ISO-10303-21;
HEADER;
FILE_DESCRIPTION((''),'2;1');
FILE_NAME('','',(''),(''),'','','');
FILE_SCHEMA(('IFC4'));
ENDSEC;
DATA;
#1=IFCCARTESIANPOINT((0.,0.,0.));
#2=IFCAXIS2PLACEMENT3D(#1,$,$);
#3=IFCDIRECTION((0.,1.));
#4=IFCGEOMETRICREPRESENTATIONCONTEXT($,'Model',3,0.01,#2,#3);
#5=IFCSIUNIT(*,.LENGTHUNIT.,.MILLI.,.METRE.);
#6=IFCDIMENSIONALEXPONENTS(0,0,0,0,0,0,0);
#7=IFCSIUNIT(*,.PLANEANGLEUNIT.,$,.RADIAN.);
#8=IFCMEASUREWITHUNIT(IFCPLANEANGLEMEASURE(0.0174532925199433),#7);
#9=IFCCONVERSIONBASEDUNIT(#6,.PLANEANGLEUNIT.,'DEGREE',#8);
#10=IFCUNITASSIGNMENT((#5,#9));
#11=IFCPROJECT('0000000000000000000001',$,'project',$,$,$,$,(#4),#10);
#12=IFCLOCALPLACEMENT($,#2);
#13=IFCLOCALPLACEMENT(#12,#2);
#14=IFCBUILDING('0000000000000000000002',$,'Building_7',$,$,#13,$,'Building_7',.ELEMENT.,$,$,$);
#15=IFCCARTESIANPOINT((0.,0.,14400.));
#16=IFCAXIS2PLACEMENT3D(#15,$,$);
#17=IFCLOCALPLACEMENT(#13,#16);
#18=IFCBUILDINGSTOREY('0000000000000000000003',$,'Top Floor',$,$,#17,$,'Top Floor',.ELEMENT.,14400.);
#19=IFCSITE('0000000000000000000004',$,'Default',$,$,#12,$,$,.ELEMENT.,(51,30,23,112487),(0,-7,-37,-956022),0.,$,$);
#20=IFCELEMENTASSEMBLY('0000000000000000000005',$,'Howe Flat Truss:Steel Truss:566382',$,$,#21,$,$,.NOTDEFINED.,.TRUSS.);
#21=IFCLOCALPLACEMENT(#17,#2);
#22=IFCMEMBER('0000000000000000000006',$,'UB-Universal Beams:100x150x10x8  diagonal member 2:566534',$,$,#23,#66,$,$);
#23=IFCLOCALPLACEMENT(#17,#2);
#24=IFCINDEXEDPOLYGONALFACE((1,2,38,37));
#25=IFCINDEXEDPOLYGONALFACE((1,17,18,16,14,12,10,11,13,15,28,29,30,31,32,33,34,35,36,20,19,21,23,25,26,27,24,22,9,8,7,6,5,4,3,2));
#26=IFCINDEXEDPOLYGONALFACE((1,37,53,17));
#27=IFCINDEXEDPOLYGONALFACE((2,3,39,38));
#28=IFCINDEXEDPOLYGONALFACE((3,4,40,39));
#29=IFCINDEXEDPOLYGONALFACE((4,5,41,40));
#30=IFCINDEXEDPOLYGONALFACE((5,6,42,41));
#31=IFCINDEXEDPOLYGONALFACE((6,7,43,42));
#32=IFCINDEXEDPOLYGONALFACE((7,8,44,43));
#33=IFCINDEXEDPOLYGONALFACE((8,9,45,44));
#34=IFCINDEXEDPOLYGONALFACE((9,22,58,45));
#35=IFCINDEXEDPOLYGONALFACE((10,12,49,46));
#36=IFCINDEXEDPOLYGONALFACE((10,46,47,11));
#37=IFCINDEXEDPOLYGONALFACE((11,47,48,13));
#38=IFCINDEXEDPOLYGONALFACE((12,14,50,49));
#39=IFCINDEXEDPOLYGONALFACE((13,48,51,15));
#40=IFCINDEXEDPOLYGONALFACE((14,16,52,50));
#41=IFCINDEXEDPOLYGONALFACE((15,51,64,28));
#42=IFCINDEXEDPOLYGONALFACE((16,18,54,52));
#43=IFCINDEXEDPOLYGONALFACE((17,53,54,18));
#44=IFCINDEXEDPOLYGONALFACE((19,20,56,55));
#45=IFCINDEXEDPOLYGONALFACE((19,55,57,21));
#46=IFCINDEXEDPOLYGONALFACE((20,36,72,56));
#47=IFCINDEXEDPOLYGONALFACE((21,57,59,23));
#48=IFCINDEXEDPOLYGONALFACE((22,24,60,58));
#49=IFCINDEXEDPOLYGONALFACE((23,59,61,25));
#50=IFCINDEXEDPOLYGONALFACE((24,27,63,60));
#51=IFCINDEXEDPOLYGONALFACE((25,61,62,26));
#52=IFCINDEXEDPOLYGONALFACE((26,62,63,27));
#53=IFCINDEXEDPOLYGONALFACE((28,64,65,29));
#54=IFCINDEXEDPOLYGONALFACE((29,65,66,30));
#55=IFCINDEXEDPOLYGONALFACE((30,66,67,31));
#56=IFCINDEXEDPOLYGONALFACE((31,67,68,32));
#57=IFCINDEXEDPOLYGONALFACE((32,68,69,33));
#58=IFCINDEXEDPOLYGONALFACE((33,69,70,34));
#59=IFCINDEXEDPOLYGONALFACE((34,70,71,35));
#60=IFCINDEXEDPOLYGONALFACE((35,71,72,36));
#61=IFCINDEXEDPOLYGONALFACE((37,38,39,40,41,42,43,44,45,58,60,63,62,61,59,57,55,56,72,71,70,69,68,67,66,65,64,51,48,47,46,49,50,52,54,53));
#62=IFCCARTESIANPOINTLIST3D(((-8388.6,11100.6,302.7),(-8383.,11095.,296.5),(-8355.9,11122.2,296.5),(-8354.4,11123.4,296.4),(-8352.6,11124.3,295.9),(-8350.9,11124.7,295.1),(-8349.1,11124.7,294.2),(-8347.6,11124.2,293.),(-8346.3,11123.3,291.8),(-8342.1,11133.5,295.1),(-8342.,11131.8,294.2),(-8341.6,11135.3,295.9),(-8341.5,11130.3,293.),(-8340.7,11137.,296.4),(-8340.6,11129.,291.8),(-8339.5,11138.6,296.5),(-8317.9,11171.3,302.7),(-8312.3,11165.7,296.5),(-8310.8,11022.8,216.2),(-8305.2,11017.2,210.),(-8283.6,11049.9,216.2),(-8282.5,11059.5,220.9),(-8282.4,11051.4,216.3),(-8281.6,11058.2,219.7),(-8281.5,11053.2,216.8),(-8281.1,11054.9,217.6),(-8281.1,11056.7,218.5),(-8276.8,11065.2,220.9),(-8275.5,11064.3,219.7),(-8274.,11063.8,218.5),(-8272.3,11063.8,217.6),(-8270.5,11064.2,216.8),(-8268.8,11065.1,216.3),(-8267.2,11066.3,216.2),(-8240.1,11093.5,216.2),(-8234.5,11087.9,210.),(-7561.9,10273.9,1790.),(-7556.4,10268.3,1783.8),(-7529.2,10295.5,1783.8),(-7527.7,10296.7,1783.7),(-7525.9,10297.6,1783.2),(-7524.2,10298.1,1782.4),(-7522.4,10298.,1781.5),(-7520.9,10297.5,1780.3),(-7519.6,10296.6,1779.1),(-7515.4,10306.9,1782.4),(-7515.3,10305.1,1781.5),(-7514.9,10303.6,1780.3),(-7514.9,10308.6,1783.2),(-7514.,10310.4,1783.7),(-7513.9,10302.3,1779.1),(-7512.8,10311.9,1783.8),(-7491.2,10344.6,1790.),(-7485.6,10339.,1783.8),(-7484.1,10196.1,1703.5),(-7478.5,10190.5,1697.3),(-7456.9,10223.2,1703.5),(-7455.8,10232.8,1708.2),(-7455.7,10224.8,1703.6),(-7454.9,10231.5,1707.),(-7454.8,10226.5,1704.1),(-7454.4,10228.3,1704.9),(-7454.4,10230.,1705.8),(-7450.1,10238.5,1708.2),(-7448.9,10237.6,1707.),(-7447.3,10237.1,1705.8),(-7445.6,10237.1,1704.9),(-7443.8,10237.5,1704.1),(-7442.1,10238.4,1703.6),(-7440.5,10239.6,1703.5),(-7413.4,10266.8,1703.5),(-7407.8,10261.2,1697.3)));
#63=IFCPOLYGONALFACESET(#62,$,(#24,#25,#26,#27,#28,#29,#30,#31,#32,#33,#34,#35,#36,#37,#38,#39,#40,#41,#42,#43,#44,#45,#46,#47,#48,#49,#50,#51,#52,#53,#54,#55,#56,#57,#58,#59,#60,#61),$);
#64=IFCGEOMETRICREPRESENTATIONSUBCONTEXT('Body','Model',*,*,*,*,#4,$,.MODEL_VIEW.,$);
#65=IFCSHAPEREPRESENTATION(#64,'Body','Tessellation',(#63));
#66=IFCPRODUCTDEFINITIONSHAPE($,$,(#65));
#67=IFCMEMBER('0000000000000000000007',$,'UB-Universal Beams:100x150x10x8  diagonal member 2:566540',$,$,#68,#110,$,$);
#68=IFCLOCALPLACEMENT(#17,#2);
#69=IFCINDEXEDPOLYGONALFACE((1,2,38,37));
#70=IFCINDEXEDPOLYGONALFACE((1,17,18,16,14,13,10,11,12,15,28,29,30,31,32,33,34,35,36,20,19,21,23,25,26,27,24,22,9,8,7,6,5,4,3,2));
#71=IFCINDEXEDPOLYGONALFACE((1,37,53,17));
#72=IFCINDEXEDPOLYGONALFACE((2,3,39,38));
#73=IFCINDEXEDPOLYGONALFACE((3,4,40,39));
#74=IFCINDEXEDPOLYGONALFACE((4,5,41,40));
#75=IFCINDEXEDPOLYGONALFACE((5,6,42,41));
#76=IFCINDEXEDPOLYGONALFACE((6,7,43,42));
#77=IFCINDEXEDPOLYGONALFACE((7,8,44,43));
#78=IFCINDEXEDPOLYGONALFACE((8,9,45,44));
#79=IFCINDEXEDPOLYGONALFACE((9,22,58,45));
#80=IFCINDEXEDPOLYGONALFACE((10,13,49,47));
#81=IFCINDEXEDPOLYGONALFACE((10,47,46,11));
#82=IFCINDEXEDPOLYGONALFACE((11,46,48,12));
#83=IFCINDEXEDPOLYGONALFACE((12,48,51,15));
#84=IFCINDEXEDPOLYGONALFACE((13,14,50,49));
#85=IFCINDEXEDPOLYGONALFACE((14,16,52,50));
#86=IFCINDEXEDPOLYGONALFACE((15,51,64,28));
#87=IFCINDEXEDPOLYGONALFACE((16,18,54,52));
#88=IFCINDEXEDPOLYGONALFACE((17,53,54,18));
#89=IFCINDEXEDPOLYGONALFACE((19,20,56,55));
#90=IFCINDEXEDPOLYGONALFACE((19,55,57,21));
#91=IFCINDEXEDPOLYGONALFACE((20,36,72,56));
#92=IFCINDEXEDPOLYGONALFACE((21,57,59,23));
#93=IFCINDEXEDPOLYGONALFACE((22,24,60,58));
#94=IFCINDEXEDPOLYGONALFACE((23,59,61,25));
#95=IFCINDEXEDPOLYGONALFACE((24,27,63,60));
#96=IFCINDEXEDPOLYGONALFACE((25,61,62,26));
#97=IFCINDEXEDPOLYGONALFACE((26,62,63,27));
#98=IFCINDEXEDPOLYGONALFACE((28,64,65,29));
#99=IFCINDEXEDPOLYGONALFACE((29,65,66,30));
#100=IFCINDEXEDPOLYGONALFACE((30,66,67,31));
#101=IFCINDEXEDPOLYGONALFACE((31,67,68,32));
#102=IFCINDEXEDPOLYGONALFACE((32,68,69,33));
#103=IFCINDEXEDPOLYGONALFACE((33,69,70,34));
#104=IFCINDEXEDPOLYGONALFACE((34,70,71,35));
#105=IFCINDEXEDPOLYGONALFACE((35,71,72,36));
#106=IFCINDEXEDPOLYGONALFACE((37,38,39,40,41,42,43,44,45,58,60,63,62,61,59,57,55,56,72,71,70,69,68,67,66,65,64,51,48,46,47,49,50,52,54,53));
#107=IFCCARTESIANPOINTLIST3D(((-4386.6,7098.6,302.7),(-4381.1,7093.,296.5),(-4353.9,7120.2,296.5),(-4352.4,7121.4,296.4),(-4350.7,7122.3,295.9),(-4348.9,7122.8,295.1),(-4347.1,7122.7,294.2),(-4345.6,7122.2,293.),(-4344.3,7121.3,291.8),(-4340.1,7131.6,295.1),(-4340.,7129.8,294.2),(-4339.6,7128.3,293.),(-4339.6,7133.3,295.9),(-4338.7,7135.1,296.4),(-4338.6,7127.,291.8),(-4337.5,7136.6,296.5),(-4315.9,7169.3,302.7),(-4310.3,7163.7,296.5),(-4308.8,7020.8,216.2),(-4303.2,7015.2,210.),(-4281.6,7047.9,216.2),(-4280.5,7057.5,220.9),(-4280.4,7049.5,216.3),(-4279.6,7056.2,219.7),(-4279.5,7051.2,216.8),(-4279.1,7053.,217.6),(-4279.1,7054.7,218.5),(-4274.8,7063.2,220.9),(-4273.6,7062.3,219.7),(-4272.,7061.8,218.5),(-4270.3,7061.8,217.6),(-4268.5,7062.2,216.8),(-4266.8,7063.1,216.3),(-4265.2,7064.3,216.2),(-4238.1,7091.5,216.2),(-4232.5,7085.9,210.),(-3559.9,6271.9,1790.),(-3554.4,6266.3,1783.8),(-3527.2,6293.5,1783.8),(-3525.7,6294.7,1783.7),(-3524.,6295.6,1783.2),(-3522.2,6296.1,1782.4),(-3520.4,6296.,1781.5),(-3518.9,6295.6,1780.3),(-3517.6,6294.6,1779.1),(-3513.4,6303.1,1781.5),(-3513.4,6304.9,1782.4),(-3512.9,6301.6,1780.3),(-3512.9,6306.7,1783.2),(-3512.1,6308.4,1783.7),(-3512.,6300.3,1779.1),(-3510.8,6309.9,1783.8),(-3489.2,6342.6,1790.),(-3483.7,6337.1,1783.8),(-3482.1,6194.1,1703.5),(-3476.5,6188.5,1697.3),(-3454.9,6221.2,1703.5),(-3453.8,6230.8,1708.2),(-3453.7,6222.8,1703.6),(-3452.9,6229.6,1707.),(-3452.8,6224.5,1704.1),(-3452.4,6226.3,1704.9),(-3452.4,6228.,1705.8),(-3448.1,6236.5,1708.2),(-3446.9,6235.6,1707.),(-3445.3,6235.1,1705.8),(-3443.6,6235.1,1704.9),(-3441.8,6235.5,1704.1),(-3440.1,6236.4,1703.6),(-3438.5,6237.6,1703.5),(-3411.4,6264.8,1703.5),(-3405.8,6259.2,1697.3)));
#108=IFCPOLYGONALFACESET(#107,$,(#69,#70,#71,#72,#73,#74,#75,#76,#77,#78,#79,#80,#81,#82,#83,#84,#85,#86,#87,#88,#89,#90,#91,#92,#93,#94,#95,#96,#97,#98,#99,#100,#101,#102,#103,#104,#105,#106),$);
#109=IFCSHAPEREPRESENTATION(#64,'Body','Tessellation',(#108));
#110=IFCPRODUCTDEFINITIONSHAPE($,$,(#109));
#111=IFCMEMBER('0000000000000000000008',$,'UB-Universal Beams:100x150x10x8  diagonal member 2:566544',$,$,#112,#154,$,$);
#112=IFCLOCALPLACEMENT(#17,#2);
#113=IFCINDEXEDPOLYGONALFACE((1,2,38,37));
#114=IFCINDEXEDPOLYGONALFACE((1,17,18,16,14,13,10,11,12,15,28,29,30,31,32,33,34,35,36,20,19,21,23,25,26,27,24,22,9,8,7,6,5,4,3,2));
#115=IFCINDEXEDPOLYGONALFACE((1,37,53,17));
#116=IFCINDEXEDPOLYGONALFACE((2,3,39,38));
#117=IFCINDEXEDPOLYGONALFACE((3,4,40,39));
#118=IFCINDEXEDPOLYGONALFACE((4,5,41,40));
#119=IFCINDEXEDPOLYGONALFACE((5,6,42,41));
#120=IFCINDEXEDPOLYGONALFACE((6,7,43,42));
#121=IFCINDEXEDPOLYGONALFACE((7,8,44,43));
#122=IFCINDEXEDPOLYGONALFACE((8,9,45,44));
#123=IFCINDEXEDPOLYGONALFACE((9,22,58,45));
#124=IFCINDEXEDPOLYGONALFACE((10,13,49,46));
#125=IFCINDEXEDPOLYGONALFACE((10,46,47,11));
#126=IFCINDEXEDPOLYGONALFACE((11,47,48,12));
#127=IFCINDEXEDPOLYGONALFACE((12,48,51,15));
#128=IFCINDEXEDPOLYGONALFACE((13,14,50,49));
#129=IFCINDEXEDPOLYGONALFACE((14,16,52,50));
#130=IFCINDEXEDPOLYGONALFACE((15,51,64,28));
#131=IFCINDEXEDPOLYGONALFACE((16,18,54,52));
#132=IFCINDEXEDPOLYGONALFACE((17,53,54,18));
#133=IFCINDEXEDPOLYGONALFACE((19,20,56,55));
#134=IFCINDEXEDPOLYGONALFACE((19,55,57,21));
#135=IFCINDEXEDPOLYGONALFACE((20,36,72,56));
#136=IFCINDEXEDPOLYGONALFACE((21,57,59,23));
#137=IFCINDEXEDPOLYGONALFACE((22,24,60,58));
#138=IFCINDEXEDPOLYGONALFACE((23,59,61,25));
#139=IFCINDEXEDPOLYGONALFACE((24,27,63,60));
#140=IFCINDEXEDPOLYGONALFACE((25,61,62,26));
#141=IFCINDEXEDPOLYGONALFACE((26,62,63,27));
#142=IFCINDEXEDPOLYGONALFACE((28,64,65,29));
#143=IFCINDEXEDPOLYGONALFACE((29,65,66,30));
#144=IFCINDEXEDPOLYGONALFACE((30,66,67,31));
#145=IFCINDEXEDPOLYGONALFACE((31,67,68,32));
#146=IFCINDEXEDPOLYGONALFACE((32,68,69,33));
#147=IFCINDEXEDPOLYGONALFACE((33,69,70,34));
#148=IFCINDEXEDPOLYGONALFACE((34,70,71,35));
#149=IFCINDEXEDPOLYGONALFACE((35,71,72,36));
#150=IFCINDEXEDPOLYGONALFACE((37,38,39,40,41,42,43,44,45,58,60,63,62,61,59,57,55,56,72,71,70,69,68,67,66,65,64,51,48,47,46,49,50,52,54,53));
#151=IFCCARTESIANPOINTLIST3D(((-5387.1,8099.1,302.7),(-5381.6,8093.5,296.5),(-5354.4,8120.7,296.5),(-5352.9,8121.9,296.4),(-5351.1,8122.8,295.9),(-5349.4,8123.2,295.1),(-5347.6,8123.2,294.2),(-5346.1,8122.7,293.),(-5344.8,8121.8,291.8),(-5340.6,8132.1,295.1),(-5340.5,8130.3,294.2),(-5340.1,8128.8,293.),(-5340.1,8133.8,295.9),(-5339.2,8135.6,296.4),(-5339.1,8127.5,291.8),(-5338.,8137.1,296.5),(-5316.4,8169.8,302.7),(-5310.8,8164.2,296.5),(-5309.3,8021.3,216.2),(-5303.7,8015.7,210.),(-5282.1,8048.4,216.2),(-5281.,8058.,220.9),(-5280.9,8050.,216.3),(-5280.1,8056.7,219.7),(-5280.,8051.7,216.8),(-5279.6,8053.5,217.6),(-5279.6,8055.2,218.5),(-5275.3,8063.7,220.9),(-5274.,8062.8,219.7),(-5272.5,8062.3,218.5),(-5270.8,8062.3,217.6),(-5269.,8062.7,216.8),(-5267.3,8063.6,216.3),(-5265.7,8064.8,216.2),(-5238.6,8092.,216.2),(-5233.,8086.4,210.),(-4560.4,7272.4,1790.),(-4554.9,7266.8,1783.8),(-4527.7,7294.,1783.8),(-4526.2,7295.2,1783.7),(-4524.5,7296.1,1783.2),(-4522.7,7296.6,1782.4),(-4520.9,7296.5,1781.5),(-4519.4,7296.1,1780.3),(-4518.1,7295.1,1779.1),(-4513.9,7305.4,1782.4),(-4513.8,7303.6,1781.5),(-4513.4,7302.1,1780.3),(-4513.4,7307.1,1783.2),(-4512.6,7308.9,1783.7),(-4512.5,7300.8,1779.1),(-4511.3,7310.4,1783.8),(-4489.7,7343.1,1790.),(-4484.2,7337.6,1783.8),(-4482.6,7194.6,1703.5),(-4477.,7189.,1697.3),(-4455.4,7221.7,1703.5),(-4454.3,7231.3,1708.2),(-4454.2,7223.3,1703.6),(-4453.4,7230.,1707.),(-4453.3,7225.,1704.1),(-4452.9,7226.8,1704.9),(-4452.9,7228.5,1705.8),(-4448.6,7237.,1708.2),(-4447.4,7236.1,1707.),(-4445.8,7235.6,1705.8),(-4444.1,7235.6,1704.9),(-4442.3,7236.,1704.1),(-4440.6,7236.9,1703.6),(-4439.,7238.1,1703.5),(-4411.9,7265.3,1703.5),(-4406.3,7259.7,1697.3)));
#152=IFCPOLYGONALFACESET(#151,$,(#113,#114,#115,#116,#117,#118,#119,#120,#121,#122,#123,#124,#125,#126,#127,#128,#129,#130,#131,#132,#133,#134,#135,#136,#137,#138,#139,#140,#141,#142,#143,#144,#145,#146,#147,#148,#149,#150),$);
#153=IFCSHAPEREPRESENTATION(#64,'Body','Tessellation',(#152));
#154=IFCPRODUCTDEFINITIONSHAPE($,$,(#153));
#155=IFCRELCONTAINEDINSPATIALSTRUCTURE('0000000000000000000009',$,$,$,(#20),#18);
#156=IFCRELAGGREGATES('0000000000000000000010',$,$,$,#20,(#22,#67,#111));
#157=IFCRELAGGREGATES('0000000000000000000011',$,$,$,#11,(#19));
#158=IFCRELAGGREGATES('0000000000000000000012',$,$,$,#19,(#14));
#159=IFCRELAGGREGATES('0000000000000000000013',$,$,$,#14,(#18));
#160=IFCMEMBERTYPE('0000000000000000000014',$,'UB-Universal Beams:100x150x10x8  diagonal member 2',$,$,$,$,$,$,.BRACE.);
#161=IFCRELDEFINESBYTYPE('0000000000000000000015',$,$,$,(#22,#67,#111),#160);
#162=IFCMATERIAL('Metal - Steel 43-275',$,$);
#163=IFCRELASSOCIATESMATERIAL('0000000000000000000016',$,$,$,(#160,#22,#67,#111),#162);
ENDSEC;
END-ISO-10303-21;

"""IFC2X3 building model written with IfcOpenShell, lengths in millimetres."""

from ifc_helpers import new_model, entity, si_unit, converted_unit, direction, frame, frame_2d, origin, place, context, subcontext, project, spatial, polyline, circle_curve, parameter, trimmed, segment, composite_curve, outline, extrude, source, transform, mapped, material, type_object, type_shapes, element, aggregate, save


model = new_model("IFC2X3")

# Units and contexts
model_context = context("Model", 3, precision=0.01, world=origin(), true_north=direction((0.0, 1.0)))
body_context = subcontext(model_context, "Body", "Model", "MODEL_VIEW")
ifc_project = project(units=[si_unit("LENGTHUNIT", "METRE", prefix="MILLI"), converted_unit("PLANEANGLEUNIT", "DEGREE", entity("IfcPlaneAngleMeasure", 0.0174532925199433), si_unit("PLANEANGLEUNIT", "RADIAN"), dimensions=[0, 0, 0, 0, 0, 0, 0])], contexts=[model_context])

# Site, building, storey
site_placement = place(None, origin())
site = spatial("IfcSite", under=ifc_project, at=site_placement, Name="Default", CompositionType="ELEMENT", RefLatitude=(51, 30, 23, 112487), RefLongitude=(0, -7, -37, -956022), RefElevation=0.0)
building_placement = place(site_placement, origin())
building = spatial("IfcBuilding", under=site, at=building_placement, Name="Building_7", LongName="Building_7", CompositionType="ELEMENT")
storey_placement = place(building_placement, frame((0.0, 0.0, 14400.0)))
storey = spatial("IfcBuildingStorey", under=building, at=storey_placement, Name="Top Floor", LongName="Top Floor", CompositionType="ELEMENT", Elevation=14400.0)

# Shared definitions
ifc_material = material(Name="Metal - Steel 43-275")

# Element assembly
assembly_1_placement = place(storey_placement, origin())
assembly_1 = element("IfcElementAssembly", 1, at=assembly_1_placement, inside=storey, Name="Howe Flat Truss:Steel Truss:566382", AssemblyPlace="NOTDEFINED", PredefinedType="TRUSS")

# Members
member_type_1 = type_object("IfcMemberType", Name="UB-Universal Beams:100x150x10x8  diagonal member 2", PredefinedType="BRACE", material=ifc_material)
shared_shape_1 = source(origin(), body_context, "Body", "SweptSolid", [
    extrude(outline(composite_curve([segment(polyline([(-50.0, -65.0), (-50.0, -75.0)]), True, "CONTINUOUS"), segment(polyline([(-50.0, -75.0), (50.0, -75.0)]), True, "CONTINUOUS"), segment(polyline([(50.0, -75.0), (50.0, -65.0)]), True, "CONTINUOUS"), segment(polyline([(50.0, -65.0), (11.6, -65.0)]), True, "CONTINUOUS"), segment(trimmed(circle_curve(frame_2d((11.6, -57.4), x_axis=(1.0, 0.0)), 7.6), [parameter(180.0)], [parameter(270.0)], True, "PARAMETER"), False, "CONTINUOUS"), segment(polyline([(4.0, -57.4), (4.0, 57.4)]), True, "CONTINUOUS"), segment(trimmed(circle_curve(frame_2d((11.6, 57.4), x_axis=(1.0, 0.0)), 7.6), [parameter(90.0)], [parameter(180.0)], True, "PARAMETER"), False, "CONTINUOUS"), segment(polyline([(11.6, 65.0), (50.0, 65.0)]), True, "CONTINUOUS"), segment(polyline([(50.0, 65.0), (50.0, 75.0)]), True, "CONTINUOUS"), segment(polyline([(50.0, 75.0), (-50.0, 75.0)]), True, "CONTINUOUS"), segment(polyline([(-50.0, 75.0), (-50.0, 65.0)]), True, "CONTINUOUS"), segment(polyline([(-50.0, 65.0), (-11.6, 65.0)]), True, "CONTINUOUS"), segment(trimmed(circle_curve(frame_2d((-11.6, 57.4), x_axis=(1.0, 0.0)), 7.6), [parameter(360.0)], [parameter(90.0)], True, "PARAMETER"), False, "CONTINUOUS"), segment(polyline([(-4.0, 57.4), (-4.0, -57.4)]), True, "CONTINUOUS"), segment(trimmed(circle_curve(frame_2d((-11.6, -57.4), x_axis=(1.0, 0.0)), 7.6), [parameter(270.0)], [parameter(360.0)], True, "PARAMETER"), False, "CONTINUOUS"), segment(polyline([(-11.6, -65.0), (-50.0, -65.0)]), True, "CONTINUOUS")], self_intersect=False)), frame((-945.9, 0.0, 0.0), z_axis=(-1.0, 0.0, 0.0), x_axis=(0.0, -1.0, 0.0)), (0.0, 0.0, -1.0), 1891.8),
])
type_shapes(member_type_1, [shared_shape_1])
member_1_placement = place(assembly_1_placement, frame((-7898.2, 10680.9, 1000.0), z_axis=(0.555916, -0.555916, -0.617992), x_axis=(-0.436986, 0.436986, -0.786184)))
member_1 = element("IfcMember", 2, at=member_1_placement, type_object=member_type_1, material=ifc_material, Name="UB-Universal Beams:100x150x10x8  diagonal member 2:566534", context=body_context, shape_type="MappedRepresentation", body=[
    mapped(shared_shape_1, transform((0.0, 0.0, 0.0), scale=1.0)),
])
member_2_placement = place(assembly_1_placement, frame((-3896.2, 6678.9, 1000.0), z_axis=(0.555916, -0.555916, -0.617992), x_axis=(-0.436986, 0.436986, -0.786184)))
member_2 = element("IfcMember", 3, at=member_2_placement, type_object=member_type_1, material=ifc_material, Name="UB-Universal Beams:100x150x10x8  diagonal member 2:566540", context=body_context, shape_type="MappedRepresentation", body=[
    mapped(shared_shape_1, transform((0.0, 0.0, 0.0), scale=1.0)),
])
member_3_placement = place(assembly_1_placement, frame((-4896.7, 7679.4, 1000.0), z_axis=(0.555916, -0.555916, -0.617992), x_axis=(-0.436986, 0.436986, -0.786184)))
member_3 = element("IfcMember", 4, at=member_3_placement, type_object=member_type_1, material=ifc_material, Name="UB-Universal Beams:100x150x10x8  diagonal member 2:566544", context=body_context, shape_type="MappedRepresentation", body=[
    mapped(shared_shape_1, transform((0.0, 0.0, 0.0), scale=1.0)),
])
aggregate(assembly_1, [member_1, member_2, member_3])

save(model, "model.ifc")
